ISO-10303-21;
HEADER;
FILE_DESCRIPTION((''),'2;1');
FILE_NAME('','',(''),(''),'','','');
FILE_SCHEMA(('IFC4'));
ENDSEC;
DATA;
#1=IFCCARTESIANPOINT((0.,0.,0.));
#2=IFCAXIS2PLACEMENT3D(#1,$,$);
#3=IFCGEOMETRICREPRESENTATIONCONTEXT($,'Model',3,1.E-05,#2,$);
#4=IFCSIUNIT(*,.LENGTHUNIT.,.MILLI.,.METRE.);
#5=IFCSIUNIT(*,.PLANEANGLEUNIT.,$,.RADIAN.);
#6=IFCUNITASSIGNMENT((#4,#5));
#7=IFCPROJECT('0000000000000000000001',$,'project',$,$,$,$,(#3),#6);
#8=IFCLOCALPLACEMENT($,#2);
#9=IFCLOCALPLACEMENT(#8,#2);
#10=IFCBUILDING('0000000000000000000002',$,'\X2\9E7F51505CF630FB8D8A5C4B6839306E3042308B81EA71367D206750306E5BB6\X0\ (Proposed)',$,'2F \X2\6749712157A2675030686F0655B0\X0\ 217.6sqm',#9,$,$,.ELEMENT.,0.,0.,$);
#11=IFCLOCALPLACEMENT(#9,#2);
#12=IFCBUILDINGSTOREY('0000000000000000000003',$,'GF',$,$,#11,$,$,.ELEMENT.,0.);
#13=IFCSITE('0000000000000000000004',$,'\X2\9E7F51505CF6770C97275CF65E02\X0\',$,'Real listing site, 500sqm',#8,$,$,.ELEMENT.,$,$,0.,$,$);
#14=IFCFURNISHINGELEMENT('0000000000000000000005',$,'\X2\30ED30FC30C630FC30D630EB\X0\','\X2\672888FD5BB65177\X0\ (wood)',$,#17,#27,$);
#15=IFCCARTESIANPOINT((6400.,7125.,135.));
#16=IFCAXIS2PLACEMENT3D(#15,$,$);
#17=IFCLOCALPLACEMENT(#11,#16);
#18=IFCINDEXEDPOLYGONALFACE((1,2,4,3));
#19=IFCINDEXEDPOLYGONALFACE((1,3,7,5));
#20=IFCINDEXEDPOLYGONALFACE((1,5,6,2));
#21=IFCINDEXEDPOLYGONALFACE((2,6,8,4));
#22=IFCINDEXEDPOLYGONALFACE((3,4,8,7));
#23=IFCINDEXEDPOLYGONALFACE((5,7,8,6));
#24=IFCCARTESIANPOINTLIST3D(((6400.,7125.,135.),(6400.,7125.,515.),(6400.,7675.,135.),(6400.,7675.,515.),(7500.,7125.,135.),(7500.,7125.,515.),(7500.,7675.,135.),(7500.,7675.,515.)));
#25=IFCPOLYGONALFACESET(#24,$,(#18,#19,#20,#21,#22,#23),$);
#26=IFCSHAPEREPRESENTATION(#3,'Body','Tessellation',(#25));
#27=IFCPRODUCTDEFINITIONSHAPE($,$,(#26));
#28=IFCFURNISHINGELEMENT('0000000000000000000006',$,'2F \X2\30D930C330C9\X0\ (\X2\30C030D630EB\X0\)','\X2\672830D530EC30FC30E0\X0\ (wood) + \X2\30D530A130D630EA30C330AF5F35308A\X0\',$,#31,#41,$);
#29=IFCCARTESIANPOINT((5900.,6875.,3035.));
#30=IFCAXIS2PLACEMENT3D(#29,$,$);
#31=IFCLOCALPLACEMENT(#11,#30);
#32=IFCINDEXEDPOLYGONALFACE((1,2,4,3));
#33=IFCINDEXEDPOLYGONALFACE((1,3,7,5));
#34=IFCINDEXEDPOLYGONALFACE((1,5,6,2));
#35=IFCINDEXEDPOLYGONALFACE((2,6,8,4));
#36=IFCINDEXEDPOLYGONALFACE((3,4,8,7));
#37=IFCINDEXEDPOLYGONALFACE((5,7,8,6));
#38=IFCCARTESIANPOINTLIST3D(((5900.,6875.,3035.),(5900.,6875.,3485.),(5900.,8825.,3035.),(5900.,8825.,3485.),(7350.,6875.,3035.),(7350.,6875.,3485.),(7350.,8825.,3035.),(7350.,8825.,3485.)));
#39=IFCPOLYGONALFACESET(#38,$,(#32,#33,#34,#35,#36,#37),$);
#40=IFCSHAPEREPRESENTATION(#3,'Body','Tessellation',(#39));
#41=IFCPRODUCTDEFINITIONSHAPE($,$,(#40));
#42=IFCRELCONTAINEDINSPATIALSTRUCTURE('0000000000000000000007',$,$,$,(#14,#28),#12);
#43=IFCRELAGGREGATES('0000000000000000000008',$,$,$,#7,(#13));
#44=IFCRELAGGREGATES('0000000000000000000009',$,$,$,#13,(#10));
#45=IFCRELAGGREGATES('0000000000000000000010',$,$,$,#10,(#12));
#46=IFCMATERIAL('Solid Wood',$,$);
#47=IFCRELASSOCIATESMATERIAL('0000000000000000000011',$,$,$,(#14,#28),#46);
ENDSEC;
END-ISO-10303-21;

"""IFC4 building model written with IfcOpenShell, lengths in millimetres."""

from ifc_helpers import new_model, si_unit, frame, frame_2d, origin, place, context, project, spatial, rectangle, extrude, material, element, save


model = new_model("IFC4")

# Units and contexts
model_context = context("Model", 3, precision=1e-05, world=origin())
ifc_project = project(units=[si_unit("LENGTHUNIT", "METRE", prefix="MILLI"), si_unit("PLANEANGLEUNIT", "RADIAN")], contexts=[model_context])

# Site, building, storey
site_placement = place(None, origin())
site = spatial("IfcSite", under=ifc_project, at=site_placement, Name="鹿児島県霧島市", ObjectType="Real listing site, 500sqm", CompositionType="ELEMENT", RefElevation=0.0)
building_placement = place(site_placement, origin())
building = spatial("IfcBuilding", under=site, at=building_placement, Name="鹿児島・越屋根のある自然素材の家 (Proposed)", ObjectType="2F 杉無垢材と漆喰 217.6sqm", CompositionType="ELEMENT", ElevationOfRefHeight=0.0, ElevationOfTerrain=0.0)
storey_placement = place(building_placement, origin())
storey = spatial("IfcBuildingStorey", under=building, at=storey_placement, Name="GF", CompositionType="ELEMENT", Elevation=0.0)

# Shared definitions
ifc_material_1 = material(Name="Solid Wood")

# Furnishing elements
furnishing_1_placement = place(storey_placement, frame((6400.0, 7125.0, 135.0)))
element("IfcFurnishingElement", 1, at=furnishing_1_placement, inside=storey, material=ifc_material_1, Name="ローテーブル", Description="木製家具 (wood)", context=model_context, shape_type="SweptSolid", body=[
    extrude(rectangle(XDim=1100.0, YDim=550.0, at=frame_2d((550.0, 275.0))), frame((6400.0, 7125.0, 135.0)), (0.0, 0.0, 1.0), 380.0),
])
furnishing_2_placement = place(storey_placement, frame((5900.0, 6875.0, 3035.0)))
element("IfcFurnishingElement", 2, at=furnishing_2_placement, inside=storey, material=ifc_material_1, Name="2F ベッド (ダブル)", Description="木フレーム (wood) + ファブリック張り", context=model_context, shape_type="SweptSolid", body=[
    extrude(rectangle(XDim=1450.0, YDim=1950.0, at=frame_2d((725.0, 975.0))), frame((5900.0, 6875.0, 3035.0)), (0.0, 0.0, 1.0), 450.0),
])

save(model, "model.ifc")
